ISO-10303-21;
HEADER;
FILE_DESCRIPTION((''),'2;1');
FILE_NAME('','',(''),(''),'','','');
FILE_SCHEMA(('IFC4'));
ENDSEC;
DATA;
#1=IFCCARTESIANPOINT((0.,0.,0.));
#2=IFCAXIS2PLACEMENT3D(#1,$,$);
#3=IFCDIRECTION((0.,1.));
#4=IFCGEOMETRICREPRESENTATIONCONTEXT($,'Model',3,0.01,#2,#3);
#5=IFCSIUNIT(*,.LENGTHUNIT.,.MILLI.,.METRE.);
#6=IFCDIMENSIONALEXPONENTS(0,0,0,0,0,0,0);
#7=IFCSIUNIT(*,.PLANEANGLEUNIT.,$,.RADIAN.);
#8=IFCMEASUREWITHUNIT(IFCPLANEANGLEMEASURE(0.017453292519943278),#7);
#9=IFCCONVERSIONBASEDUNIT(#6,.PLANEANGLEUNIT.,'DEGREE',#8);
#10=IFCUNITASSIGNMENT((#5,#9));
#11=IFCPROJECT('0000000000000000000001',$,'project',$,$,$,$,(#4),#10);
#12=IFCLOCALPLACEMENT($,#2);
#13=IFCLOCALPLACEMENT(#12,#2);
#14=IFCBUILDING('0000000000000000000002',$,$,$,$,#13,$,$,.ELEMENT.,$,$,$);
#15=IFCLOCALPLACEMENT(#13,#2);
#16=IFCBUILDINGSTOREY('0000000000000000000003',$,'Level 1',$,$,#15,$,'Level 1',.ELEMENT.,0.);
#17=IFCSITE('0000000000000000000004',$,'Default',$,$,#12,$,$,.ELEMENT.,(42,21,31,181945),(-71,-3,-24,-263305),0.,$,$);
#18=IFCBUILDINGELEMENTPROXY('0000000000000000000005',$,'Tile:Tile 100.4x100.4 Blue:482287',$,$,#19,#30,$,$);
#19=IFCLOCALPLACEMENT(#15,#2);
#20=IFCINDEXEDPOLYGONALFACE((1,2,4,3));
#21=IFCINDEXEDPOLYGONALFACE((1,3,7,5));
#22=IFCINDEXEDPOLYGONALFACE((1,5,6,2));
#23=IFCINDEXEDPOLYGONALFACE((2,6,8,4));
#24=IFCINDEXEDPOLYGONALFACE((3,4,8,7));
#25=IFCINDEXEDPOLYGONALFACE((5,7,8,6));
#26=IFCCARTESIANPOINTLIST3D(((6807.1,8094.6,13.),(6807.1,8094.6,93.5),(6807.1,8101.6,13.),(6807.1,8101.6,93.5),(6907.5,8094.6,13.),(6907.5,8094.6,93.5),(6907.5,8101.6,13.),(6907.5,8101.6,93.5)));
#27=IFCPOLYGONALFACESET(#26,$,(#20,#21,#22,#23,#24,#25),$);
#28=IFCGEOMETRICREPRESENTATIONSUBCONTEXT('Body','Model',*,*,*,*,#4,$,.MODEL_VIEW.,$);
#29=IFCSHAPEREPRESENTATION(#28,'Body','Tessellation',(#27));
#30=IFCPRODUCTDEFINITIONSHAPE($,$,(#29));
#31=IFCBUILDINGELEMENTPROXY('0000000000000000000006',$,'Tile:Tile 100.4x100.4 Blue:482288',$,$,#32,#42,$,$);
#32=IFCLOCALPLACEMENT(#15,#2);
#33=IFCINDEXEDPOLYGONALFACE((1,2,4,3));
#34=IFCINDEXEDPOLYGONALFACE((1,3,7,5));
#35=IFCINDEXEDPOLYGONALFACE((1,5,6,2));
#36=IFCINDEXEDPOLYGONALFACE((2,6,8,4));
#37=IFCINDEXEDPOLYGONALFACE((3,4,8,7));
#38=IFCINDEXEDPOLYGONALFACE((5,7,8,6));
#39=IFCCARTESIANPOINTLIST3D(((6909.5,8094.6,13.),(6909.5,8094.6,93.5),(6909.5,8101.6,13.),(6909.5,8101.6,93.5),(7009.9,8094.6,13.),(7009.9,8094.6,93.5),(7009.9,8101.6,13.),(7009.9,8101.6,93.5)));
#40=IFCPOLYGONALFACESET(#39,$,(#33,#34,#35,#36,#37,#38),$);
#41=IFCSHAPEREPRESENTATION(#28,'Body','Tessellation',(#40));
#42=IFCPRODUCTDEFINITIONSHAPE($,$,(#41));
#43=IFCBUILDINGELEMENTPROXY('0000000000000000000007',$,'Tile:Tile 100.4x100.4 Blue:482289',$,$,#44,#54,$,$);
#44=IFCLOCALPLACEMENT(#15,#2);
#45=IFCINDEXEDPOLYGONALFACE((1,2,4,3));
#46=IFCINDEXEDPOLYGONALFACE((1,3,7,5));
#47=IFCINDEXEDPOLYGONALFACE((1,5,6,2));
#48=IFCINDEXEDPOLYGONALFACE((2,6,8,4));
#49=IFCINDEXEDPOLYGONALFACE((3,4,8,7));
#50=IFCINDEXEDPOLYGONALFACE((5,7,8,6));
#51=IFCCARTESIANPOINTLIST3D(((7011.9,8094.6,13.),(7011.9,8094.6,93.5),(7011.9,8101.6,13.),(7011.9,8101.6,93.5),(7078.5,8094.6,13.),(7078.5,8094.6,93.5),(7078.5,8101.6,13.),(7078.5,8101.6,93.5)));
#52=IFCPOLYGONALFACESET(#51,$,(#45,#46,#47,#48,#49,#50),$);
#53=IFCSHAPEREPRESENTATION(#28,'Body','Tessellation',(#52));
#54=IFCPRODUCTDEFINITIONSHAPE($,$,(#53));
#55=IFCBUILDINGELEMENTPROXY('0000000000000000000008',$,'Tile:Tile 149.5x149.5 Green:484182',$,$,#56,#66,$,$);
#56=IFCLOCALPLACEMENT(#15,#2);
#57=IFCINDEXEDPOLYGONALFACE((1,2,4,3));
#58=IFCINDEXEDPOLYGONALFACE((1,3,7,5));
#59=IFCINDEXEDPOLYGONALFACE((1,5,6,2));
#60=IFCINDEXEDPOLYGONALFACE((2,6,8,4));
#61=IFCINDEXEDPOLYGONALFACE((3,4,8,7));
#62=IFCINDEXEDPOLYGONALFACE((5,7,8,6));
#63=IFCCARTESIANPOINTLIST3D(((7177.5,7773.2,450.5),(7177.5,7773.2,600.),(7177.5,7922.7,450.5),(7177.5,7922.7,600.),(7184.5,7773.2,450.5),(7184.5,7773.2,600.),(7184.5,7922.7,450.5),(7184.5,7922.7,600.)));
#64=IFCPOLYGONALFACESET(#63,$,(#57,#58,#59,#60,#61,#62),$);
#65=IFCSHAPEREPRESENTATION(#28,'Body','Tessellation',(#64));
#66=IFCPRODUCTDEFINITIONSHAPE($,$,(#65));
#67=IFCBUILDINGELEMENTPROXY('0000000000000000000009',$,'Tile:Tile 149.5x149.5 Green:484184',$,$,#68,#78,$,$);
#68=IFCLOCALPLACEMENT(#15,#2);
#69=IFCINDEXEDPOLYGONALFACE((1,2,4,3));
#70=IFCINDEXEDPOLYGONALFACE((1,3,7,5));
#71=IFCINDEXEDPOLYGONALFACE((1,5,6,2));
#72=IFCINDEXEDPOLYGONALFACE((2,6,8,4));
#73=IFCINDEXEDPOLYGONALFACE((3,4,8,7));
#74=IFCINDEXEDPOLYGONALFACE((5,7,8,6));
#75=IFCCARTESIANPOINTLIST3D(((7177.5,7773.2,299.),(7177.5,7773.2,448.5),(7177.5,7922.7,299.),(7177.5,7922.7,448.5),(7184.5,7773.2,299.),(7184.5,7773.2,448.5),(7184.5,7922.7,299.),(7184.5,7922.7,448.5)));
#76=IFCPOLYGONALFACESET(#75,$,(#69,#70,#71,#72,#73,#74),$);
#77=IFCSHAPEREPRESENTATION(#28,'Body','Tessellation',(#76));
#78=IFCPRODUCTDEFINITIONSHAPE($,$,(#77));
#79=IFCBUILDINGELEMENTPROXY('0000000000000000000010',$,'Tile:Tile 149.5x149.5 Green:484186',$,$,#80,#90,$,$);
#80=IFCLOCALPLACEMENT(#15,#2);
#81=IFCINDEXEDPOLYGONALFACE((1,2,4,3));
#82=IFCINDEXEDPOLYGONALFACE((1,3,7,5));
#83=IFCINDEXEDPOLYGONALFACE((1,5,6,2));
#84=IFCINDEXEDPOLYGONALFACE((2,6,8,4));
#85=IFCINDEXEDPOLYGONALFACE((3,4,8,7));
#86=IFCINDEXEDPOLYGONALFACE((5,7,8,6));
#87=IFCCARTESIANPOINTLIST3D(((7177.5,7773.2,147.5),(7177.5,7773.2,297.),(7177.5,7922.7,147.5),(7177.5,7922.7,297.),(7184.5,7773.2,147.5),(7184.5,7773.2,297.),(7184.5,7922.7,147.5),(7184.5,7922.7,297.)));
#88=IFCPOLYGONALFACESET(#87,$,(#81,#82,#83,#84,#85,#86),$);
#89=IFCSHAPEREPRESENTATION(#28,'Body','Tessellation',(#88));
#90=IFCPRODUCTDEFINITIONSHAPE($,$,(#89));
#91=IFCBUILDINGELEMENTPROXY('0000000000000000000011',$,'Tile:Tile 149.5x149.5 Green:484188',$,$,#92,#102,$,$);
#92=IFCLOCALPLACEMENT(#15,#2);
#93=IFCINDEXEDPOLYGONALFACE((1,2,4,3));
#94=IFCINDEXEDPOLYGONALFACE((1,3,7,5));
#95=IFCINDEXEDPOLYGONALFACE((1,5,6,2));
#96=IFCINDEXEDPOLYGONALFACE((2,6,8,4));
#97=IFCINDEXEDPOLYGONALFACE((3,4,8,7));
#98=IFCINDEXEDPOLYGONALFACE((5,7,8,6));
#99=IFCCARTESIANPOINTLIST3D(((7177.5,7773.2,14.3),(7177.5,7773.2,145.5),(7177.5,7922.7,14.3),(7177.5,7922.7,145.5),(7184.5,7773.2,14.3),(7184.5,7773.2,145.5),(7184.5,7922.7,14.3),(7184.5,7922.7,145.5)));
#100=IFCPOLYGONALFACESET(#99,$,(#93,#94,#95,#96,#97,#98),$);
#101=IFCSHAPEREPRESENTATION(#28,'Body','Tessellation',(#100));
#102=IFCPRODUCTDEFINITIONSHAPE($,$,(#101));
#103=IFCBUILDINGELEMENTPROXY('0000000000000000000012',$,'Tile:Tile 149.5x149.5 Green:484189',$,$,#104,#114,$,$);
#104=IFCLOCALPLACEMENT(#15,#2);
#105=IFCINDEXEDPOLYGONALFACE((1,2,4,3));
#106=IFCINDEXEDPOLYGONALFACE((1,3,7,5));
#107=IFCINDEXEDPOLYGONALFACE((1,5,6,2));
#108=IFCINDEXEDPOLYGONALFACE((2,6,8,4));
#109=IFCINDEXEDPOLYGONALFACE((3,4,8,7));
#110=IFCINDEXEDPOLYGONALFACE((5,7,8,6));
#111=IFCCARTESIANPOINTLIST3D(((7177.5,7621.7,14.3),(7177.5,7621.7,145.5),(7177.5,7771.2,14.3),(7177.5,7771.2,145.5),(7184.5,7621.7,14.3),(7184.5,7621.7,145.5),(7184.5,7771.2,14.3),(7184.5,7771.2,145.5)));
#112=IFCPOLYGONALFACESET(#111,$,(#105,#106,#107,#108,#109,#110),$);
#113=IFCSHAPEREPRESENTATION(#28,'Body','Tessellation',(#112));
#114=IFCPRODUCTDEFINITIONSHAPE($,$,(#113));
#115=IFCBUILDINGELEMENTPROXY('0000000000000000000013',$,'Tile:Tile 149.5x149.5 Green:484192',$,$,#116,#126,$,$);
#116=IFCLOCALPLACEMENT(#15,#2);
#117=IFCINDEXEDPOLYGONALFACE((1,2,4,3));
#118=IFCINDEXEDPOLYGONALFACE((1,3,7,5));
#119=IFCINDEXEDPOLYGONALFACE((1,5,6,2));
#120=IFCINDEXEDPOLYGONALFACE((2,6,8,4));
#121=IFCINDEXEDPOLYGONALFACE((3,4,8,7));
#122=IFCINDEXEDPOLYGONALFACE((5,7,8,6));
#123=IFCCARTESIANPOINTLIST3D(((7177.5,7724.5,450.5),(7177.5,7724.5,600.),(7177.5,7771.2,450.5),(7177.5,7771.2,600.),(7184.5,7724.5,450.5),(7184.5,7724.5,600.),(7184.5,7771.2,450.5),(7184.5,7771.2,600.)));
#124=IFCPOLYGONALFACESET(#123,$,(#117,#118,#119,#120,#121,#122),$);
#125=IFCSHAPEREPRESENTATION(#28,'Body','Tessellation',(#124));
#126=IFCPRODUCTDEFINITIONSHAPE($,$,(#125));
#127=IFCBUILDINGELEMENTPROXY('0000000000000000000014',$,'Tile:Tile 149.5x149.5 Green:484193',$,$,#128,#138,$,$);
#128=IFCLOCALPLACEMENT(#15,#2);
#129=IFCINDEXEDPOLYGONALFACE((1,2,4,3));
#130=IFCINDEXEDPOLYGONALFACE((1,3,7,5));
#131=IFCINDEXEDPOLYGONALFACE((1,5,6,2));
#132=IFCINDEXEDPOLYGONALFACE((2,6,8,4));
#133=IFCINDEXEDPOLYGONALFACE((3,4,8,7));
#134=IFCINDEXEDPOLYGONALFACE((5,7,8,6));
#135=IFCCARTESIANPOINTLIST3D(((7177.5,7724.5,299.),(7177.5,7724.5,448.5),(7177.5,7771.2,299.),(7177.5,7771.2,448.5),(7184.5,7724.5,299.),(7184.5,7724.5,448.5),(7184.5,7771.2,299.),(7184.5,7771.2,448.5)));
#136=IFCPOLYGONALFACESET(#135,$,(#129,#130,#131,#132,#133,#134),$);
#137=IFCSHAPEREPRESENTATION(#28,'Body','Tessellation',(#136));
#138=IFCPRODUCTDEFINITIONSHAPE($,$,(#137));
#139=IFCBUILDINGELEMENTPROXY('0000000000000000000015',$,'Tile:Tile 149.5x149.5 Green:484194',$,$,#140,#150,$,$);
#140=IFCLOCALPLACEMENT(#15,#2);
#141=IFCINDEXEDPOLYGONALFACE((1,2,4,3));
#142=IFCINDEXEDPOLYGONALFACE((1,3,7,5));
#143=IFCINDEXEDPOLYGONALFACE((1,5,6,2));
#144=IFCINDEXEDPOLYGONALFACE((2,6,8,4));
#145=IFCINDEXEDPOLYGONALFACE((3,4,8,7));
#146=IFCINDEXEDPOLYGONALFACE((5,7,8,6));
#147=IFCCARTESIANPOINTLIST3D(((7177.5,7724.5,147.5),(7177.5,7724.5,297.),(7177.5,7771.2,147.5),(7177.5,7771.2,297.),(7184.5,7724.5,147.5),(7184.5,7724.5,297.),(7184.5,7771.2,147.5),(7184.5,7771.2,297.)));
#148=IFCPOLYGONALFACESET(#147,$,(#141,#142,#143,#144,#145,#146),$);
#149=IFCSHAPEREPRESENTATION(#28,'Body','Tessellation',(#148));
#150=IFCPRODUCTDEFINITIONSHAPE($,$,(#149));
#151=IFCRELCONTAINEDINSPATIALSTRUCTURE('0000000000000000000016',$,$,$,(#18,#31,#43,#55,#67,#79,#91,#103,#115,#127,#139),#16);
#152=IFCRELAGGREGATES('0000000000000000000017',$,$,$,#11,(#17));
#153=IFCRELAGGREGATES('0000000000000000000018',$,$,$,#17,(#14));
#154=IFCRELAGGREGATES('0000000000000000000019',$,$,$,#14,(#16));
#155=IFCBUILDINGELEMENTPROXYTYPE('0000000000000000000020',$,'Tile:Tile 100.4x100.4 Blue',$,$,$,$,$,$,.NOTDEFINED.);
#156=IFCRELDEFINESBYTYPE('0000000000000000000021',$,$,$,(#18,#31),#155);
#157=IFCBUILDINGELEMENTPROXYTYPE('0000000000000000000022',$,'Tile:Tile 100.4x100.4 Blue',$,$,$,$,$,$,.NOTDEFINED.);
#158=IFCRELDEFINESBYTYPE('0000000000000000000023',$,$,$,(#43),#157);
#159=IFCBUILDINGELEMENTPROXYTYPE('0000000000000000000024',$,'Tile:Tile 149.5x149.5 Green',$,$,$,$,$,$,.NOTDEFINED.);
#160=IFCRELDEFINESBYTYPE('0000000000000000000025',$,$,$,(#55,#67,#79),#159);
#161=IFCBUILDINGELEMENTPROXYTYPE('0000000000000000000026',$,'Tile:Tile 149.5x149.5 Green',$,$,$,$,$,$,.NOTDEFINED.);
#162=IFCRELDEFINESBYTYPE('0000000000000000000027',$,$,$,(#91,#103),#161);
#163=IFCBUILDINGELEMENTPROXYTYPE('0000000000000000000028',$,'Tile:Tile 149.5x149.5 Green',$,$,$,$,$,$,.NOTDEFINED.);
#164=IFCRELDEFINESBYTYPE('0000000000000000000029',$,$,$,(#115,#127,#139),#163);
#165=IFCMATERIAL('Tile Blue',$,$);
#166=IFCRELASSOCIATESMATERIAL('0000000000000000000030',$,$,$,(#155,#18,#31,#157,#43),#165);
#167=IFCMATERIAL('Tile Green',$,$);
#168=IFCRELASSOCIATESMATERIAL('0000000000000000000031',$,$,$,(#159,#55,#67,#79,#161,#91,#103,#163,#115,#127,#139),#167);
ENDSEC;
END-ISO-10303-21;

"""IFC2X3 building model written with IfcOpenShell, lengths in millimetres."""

from ifc_helpers import new_model, entity, si_unit, converted_unit, direction, frame, origin, origin_2d_with_axis, place, context, subcontext, project, spatial, rectangle, extrude, source, transform, mapped, material, type_object, type_shapes, element, save


model = new_model("IFC2X3")

# Units and contexts
model_context = context("Model", 3, precision=0.01, world=origin(), true_north=direction((0.0, 1.0)))
body_context = subcontext(model_context, "Body", "Model", "MODEL_VIEW")
ifc_project = project(units=[si_unit("LENGTHUNIT", "METRE", prefix="MILLI"), converted_unit("PLANEANGLEUNIT", "DEGREE", entity("IfcPlaneAngleMeasure", 0.017453292519943278), si_unit("PLANEANGLEUNIT", "RADIAN"), dimensions=[0, 0, 0, 0, 0, 0, 0])], contexts=[model_context])

# Site, building, storey
site_placement = place(None, origin())
site = spatial("IfcSite", under=ifc_project, at=site_placement, Name="Default", CompositionType="ELEMENT", RefLatitude=(42, 21, 31, 181945), RefLongitude=(-71, -3, -24, -263305), RefElevation=0.0)
building_placement = place(site_placement, origin())
building = spatial("IfcBuilding", under=site, at=building_placement, CompositionType="ELEMENT")
storey_placement = place(building_placement, origin())
storey = spatial("IfcBuildingStorey", under=building, at=storey_placement, Name="Level 1", LongName="Level 1", CompositionType="ELEMENT", Elevation=0.0)

# Building element proxies
ifc_material_1 = material(Name="Tile Blue")
building_element_proxy_type_1 = type_object("IfcBuildingElementProxyType", Name="Tile:Tile 100.4x100.4 Blue", PredefinedType="NOTDEFINED", material=ifc_material_1)
shared_shape_1 = source(origin(), body_context, "Body", "SweptSolid", [
    extrude(rectangle(XDim=80.5, YDim=100.4, at=origin_2d_with_axis()), frame((-50.2, -40.3, 0.0), z_axis=(0.0, 0.0, 1.0), x_axis=(0.0, -1.0, 0.0)), (0.0, 0.0, 1.0), 7.0),
])
type_shapes(building_element_proxy_type_1, [shared_shape_1])
for number, where, z_axis, x_axis, name in (
    (1, (6807.1, 8101.6, 13.0), (0.0, -1.0, 0.0), (-1.0, 0.0, 0.0), "Tile:Tile 100.4x100.4 Blue:482287"),
    (2, (6909.5, 8101.6, 13.0), (0.0, -1.0, 0.0), (-1.0, 0.0, 0.0), "Tile:Tile 100.4x100.4 Blue:482288"),
):
    element("IfcBuildingElementProxy", number, at=place(storey_placement, frame(where, z_axis=z_axis, x_axis=x_axis)), inside=storey, type_object=building_element_proxy_type_1, material=ifc_material_1, Name=name, context=body_context, shape_type="MappedRepresentation", body=[
        mapped(shared_shape_1, transform((0.0, 0.0, 0.0), scale=1.0)),
    ])
building_element_proxy_type_2 = type_object("IfcBuildingElementProxyType", Name="Tile:Tile 100.4x100.4 Blue", PredefinedType="NOTDEFINED", material=ifc_material_1)
shared_shape_2 = source(origin(), body_context, "Body", "SweptSolid", [
    extrude(rectangle(XDim=66.6, YDim=80.5, at=origin_2d_with_axis()), frame((-33.3, -40.3, 0.0), z_axis=(0.0, 0.0, 1.0), x_axis=(-1.0, 0.0, 0.0)), (0.0, 0.0, 1.0), 7.0),
])
type_shapes(building_element_proxy_type_2, [shared_shape_2])
proxy_1_placement = place(storey_placement, frame((7011.9, 8101.6, 13.0), z_axis=(0.0, -1.0, 0.0), x_axis=(-1.0, 0.0, 0.0)))
element("IfcBuildingElementProxy", 3, at=proxy_1_placement, inside=storey, type_object=building_element_proxy_type_2, material=ifc_material_1, Name="Tile:Tile 100.4x100.4 Blue:482289", context=body_context, shape_type="MappedRepresentation", body=[
    mapped(shared_shape_2, transform((0.0, 0.0, 0.0), scale=1.0)),
])
ifc_material_2 = material(Name="Tile Green")
building_element_proxy_type_3 = type_object("IfcBuildingElementProxyType", Name="Tile:Tile 149.5x149.5 Green", PredefinedType="NOTDEFINED", material=ifc_material_2)
shared_shape_3 = source(origin(), body_context, "Body", "SweptSolid", [
    extrude(rectangle(XDim=149.5, YDim=149.5, at=origin_2d_with_axis()), frame((-74.7, -74.8, 0.0), z_axis=(0.0, 0.0, 1.0), x_axis=(0.0, -1.0, 0.0)), (0.0, 0.0, 1.0), 7.0),
])
type_shapes(building_element_proxy_type_3, [shared_shape_3])
for number, where, z_axis, x_axis, name in (
    (4, (7184.5, 7922.7, 600.0), (-1.0, 0.0, 0.0), (0.0, 0.0, 1.0), "Tile:Tile 149.5x149.5 Green:484182"),
    (5, (7184.5, 7922.7, 448.5), (-1.0, 0.0, 0.0), (0.0, 0.0, 1.0), "Tile:Tile 149.5x149.5 Green:484184"),
    (6, (7184.5, 7922.7, 297.0), (-1.0, 0.0, 0.0), (0.0, 0.0, 1.0), "Tile:Tile 149.5x149.5 Green:484186"),
):
    element("IfcBuildingElementProxy", number, at=place(storey_placement, frame(where, z_axis=z_axis, x_axis=x_axis)), inside=storey, type_object=building_element_proxy_type_3, material=ifc_material_2, Name=name, context=body_context, shape_type="MappedRepresentation", body=[
        mapped(shared_shape_3, transform((0.0, 0.0, 0.0), scale=1.0)),
    ])
building_element_proxy_type_4 = type_object("IfcBuildingElementProxyType", Name="Tile:Tile 149.5x149.5 Green", PredefinedType="NOTDEFINED", material=ifc_material_2)
shared_shape_4 = source(origin(), body_context, "Body", "SweptSolid", [
    extrude(rectangle(XDim=131.2, YDim=149.5, at=origin_2d_with_axis()), frame((-65.6, -74.8, 0.0), z_axis=(0.0, 0.0, 1.0), x_axis=(-1.0, 0.0, 0.0)), (0.0, 0.0, 1.0), 7.0),
])
type_shapes(building_element_proxy_type_4, [shared_shape_4])
for number, where, z_axis, x_axis, name in (
    (7, (7184.5, 7922.7, 145.5), (-1.0, 0.0, 0.0), (0.0, 0.0, 1.0), "Tile:Tile 149.5x149.5 Green:484188"),
    (8, (7184.5, 7771.2, 145.5), (-1.0, 0.0, 0.0), (0.0, 0.0, 1.0), "Tile:Tile 149.5x149.5 Green:484189"),
):
    element("IfcBuildingElementProxy", number, at=place(storey_placement, frame(where, z_axis=z_axis, x_axis=x_axis)), inside=storey, type_object=building_element_proxy_type_4, material=ifc_material_2, Name=name, context=body_context, shape_type="MappedRepresentation", body=[
        mapped(shared_shape_4, transform((0.0, 0.0, 0.0), scale=1.0)),
    ])
building_element_proxy_type_5 = type_object("IfcBuildingElementProxyType", Name="Tile:Tile 149.5x149.5 Green", PredefinedType="NOTDEFINED", material=ifc_material_2)
shared_shape_5 = source(origin(), body_context, "Body", "SweptSolid", [
    extrude(rectangle(XDim=46.7, YDim=149.5, at=origin_2d_with_axis()), frame((-23.3, -74.8, 0.0), z_axis=(0.0, 0.0, 1.0), x_axis=(-1.0, 0.0, 0.0)), (0.0, 0.0, 1.0), 7.0),
])
type_shapes(building_element_proxy_type_5, [shared_shape_5])
for number, where, z_axis, x_axis, name in (
    (9, (7184.5, 7771.2, 450.5), (-1.0, 0.0, 0.0), (0.0, 1.0, 0.0), "Tile:Tile 149.5x149.5 Green:484192"),
    (10, (7184.5, 7771.2, 299.0), (-1.0, 0.0, 0.0), (0.0, 1.0, 0.0), "Tile:Tile 149.5x149.5 Green:484193"),
    (11, (7184.5, 7771.2, 147.5), (-1.0, 0.0, 0.0), (0.0, 1.0, 0.0), "Tile:Tile 149.5x149.5 Green:484194"),
):
    element("IfcBuildingElementProxy", number, at=place(storey_placement, frame(where, z_axis=z_axis, x_axis=x_axis)), inside=storey, type_object=building_element_proxy_type_5, material=ifc_material_2, Name=name, context=body_context, shape_type="MappedRepresentation", body=[
        mapped(shared_shape_5, transform((0.0, 0.0, 0.0), scale=1.0)),
    ])

save(model, "model.ifc")
